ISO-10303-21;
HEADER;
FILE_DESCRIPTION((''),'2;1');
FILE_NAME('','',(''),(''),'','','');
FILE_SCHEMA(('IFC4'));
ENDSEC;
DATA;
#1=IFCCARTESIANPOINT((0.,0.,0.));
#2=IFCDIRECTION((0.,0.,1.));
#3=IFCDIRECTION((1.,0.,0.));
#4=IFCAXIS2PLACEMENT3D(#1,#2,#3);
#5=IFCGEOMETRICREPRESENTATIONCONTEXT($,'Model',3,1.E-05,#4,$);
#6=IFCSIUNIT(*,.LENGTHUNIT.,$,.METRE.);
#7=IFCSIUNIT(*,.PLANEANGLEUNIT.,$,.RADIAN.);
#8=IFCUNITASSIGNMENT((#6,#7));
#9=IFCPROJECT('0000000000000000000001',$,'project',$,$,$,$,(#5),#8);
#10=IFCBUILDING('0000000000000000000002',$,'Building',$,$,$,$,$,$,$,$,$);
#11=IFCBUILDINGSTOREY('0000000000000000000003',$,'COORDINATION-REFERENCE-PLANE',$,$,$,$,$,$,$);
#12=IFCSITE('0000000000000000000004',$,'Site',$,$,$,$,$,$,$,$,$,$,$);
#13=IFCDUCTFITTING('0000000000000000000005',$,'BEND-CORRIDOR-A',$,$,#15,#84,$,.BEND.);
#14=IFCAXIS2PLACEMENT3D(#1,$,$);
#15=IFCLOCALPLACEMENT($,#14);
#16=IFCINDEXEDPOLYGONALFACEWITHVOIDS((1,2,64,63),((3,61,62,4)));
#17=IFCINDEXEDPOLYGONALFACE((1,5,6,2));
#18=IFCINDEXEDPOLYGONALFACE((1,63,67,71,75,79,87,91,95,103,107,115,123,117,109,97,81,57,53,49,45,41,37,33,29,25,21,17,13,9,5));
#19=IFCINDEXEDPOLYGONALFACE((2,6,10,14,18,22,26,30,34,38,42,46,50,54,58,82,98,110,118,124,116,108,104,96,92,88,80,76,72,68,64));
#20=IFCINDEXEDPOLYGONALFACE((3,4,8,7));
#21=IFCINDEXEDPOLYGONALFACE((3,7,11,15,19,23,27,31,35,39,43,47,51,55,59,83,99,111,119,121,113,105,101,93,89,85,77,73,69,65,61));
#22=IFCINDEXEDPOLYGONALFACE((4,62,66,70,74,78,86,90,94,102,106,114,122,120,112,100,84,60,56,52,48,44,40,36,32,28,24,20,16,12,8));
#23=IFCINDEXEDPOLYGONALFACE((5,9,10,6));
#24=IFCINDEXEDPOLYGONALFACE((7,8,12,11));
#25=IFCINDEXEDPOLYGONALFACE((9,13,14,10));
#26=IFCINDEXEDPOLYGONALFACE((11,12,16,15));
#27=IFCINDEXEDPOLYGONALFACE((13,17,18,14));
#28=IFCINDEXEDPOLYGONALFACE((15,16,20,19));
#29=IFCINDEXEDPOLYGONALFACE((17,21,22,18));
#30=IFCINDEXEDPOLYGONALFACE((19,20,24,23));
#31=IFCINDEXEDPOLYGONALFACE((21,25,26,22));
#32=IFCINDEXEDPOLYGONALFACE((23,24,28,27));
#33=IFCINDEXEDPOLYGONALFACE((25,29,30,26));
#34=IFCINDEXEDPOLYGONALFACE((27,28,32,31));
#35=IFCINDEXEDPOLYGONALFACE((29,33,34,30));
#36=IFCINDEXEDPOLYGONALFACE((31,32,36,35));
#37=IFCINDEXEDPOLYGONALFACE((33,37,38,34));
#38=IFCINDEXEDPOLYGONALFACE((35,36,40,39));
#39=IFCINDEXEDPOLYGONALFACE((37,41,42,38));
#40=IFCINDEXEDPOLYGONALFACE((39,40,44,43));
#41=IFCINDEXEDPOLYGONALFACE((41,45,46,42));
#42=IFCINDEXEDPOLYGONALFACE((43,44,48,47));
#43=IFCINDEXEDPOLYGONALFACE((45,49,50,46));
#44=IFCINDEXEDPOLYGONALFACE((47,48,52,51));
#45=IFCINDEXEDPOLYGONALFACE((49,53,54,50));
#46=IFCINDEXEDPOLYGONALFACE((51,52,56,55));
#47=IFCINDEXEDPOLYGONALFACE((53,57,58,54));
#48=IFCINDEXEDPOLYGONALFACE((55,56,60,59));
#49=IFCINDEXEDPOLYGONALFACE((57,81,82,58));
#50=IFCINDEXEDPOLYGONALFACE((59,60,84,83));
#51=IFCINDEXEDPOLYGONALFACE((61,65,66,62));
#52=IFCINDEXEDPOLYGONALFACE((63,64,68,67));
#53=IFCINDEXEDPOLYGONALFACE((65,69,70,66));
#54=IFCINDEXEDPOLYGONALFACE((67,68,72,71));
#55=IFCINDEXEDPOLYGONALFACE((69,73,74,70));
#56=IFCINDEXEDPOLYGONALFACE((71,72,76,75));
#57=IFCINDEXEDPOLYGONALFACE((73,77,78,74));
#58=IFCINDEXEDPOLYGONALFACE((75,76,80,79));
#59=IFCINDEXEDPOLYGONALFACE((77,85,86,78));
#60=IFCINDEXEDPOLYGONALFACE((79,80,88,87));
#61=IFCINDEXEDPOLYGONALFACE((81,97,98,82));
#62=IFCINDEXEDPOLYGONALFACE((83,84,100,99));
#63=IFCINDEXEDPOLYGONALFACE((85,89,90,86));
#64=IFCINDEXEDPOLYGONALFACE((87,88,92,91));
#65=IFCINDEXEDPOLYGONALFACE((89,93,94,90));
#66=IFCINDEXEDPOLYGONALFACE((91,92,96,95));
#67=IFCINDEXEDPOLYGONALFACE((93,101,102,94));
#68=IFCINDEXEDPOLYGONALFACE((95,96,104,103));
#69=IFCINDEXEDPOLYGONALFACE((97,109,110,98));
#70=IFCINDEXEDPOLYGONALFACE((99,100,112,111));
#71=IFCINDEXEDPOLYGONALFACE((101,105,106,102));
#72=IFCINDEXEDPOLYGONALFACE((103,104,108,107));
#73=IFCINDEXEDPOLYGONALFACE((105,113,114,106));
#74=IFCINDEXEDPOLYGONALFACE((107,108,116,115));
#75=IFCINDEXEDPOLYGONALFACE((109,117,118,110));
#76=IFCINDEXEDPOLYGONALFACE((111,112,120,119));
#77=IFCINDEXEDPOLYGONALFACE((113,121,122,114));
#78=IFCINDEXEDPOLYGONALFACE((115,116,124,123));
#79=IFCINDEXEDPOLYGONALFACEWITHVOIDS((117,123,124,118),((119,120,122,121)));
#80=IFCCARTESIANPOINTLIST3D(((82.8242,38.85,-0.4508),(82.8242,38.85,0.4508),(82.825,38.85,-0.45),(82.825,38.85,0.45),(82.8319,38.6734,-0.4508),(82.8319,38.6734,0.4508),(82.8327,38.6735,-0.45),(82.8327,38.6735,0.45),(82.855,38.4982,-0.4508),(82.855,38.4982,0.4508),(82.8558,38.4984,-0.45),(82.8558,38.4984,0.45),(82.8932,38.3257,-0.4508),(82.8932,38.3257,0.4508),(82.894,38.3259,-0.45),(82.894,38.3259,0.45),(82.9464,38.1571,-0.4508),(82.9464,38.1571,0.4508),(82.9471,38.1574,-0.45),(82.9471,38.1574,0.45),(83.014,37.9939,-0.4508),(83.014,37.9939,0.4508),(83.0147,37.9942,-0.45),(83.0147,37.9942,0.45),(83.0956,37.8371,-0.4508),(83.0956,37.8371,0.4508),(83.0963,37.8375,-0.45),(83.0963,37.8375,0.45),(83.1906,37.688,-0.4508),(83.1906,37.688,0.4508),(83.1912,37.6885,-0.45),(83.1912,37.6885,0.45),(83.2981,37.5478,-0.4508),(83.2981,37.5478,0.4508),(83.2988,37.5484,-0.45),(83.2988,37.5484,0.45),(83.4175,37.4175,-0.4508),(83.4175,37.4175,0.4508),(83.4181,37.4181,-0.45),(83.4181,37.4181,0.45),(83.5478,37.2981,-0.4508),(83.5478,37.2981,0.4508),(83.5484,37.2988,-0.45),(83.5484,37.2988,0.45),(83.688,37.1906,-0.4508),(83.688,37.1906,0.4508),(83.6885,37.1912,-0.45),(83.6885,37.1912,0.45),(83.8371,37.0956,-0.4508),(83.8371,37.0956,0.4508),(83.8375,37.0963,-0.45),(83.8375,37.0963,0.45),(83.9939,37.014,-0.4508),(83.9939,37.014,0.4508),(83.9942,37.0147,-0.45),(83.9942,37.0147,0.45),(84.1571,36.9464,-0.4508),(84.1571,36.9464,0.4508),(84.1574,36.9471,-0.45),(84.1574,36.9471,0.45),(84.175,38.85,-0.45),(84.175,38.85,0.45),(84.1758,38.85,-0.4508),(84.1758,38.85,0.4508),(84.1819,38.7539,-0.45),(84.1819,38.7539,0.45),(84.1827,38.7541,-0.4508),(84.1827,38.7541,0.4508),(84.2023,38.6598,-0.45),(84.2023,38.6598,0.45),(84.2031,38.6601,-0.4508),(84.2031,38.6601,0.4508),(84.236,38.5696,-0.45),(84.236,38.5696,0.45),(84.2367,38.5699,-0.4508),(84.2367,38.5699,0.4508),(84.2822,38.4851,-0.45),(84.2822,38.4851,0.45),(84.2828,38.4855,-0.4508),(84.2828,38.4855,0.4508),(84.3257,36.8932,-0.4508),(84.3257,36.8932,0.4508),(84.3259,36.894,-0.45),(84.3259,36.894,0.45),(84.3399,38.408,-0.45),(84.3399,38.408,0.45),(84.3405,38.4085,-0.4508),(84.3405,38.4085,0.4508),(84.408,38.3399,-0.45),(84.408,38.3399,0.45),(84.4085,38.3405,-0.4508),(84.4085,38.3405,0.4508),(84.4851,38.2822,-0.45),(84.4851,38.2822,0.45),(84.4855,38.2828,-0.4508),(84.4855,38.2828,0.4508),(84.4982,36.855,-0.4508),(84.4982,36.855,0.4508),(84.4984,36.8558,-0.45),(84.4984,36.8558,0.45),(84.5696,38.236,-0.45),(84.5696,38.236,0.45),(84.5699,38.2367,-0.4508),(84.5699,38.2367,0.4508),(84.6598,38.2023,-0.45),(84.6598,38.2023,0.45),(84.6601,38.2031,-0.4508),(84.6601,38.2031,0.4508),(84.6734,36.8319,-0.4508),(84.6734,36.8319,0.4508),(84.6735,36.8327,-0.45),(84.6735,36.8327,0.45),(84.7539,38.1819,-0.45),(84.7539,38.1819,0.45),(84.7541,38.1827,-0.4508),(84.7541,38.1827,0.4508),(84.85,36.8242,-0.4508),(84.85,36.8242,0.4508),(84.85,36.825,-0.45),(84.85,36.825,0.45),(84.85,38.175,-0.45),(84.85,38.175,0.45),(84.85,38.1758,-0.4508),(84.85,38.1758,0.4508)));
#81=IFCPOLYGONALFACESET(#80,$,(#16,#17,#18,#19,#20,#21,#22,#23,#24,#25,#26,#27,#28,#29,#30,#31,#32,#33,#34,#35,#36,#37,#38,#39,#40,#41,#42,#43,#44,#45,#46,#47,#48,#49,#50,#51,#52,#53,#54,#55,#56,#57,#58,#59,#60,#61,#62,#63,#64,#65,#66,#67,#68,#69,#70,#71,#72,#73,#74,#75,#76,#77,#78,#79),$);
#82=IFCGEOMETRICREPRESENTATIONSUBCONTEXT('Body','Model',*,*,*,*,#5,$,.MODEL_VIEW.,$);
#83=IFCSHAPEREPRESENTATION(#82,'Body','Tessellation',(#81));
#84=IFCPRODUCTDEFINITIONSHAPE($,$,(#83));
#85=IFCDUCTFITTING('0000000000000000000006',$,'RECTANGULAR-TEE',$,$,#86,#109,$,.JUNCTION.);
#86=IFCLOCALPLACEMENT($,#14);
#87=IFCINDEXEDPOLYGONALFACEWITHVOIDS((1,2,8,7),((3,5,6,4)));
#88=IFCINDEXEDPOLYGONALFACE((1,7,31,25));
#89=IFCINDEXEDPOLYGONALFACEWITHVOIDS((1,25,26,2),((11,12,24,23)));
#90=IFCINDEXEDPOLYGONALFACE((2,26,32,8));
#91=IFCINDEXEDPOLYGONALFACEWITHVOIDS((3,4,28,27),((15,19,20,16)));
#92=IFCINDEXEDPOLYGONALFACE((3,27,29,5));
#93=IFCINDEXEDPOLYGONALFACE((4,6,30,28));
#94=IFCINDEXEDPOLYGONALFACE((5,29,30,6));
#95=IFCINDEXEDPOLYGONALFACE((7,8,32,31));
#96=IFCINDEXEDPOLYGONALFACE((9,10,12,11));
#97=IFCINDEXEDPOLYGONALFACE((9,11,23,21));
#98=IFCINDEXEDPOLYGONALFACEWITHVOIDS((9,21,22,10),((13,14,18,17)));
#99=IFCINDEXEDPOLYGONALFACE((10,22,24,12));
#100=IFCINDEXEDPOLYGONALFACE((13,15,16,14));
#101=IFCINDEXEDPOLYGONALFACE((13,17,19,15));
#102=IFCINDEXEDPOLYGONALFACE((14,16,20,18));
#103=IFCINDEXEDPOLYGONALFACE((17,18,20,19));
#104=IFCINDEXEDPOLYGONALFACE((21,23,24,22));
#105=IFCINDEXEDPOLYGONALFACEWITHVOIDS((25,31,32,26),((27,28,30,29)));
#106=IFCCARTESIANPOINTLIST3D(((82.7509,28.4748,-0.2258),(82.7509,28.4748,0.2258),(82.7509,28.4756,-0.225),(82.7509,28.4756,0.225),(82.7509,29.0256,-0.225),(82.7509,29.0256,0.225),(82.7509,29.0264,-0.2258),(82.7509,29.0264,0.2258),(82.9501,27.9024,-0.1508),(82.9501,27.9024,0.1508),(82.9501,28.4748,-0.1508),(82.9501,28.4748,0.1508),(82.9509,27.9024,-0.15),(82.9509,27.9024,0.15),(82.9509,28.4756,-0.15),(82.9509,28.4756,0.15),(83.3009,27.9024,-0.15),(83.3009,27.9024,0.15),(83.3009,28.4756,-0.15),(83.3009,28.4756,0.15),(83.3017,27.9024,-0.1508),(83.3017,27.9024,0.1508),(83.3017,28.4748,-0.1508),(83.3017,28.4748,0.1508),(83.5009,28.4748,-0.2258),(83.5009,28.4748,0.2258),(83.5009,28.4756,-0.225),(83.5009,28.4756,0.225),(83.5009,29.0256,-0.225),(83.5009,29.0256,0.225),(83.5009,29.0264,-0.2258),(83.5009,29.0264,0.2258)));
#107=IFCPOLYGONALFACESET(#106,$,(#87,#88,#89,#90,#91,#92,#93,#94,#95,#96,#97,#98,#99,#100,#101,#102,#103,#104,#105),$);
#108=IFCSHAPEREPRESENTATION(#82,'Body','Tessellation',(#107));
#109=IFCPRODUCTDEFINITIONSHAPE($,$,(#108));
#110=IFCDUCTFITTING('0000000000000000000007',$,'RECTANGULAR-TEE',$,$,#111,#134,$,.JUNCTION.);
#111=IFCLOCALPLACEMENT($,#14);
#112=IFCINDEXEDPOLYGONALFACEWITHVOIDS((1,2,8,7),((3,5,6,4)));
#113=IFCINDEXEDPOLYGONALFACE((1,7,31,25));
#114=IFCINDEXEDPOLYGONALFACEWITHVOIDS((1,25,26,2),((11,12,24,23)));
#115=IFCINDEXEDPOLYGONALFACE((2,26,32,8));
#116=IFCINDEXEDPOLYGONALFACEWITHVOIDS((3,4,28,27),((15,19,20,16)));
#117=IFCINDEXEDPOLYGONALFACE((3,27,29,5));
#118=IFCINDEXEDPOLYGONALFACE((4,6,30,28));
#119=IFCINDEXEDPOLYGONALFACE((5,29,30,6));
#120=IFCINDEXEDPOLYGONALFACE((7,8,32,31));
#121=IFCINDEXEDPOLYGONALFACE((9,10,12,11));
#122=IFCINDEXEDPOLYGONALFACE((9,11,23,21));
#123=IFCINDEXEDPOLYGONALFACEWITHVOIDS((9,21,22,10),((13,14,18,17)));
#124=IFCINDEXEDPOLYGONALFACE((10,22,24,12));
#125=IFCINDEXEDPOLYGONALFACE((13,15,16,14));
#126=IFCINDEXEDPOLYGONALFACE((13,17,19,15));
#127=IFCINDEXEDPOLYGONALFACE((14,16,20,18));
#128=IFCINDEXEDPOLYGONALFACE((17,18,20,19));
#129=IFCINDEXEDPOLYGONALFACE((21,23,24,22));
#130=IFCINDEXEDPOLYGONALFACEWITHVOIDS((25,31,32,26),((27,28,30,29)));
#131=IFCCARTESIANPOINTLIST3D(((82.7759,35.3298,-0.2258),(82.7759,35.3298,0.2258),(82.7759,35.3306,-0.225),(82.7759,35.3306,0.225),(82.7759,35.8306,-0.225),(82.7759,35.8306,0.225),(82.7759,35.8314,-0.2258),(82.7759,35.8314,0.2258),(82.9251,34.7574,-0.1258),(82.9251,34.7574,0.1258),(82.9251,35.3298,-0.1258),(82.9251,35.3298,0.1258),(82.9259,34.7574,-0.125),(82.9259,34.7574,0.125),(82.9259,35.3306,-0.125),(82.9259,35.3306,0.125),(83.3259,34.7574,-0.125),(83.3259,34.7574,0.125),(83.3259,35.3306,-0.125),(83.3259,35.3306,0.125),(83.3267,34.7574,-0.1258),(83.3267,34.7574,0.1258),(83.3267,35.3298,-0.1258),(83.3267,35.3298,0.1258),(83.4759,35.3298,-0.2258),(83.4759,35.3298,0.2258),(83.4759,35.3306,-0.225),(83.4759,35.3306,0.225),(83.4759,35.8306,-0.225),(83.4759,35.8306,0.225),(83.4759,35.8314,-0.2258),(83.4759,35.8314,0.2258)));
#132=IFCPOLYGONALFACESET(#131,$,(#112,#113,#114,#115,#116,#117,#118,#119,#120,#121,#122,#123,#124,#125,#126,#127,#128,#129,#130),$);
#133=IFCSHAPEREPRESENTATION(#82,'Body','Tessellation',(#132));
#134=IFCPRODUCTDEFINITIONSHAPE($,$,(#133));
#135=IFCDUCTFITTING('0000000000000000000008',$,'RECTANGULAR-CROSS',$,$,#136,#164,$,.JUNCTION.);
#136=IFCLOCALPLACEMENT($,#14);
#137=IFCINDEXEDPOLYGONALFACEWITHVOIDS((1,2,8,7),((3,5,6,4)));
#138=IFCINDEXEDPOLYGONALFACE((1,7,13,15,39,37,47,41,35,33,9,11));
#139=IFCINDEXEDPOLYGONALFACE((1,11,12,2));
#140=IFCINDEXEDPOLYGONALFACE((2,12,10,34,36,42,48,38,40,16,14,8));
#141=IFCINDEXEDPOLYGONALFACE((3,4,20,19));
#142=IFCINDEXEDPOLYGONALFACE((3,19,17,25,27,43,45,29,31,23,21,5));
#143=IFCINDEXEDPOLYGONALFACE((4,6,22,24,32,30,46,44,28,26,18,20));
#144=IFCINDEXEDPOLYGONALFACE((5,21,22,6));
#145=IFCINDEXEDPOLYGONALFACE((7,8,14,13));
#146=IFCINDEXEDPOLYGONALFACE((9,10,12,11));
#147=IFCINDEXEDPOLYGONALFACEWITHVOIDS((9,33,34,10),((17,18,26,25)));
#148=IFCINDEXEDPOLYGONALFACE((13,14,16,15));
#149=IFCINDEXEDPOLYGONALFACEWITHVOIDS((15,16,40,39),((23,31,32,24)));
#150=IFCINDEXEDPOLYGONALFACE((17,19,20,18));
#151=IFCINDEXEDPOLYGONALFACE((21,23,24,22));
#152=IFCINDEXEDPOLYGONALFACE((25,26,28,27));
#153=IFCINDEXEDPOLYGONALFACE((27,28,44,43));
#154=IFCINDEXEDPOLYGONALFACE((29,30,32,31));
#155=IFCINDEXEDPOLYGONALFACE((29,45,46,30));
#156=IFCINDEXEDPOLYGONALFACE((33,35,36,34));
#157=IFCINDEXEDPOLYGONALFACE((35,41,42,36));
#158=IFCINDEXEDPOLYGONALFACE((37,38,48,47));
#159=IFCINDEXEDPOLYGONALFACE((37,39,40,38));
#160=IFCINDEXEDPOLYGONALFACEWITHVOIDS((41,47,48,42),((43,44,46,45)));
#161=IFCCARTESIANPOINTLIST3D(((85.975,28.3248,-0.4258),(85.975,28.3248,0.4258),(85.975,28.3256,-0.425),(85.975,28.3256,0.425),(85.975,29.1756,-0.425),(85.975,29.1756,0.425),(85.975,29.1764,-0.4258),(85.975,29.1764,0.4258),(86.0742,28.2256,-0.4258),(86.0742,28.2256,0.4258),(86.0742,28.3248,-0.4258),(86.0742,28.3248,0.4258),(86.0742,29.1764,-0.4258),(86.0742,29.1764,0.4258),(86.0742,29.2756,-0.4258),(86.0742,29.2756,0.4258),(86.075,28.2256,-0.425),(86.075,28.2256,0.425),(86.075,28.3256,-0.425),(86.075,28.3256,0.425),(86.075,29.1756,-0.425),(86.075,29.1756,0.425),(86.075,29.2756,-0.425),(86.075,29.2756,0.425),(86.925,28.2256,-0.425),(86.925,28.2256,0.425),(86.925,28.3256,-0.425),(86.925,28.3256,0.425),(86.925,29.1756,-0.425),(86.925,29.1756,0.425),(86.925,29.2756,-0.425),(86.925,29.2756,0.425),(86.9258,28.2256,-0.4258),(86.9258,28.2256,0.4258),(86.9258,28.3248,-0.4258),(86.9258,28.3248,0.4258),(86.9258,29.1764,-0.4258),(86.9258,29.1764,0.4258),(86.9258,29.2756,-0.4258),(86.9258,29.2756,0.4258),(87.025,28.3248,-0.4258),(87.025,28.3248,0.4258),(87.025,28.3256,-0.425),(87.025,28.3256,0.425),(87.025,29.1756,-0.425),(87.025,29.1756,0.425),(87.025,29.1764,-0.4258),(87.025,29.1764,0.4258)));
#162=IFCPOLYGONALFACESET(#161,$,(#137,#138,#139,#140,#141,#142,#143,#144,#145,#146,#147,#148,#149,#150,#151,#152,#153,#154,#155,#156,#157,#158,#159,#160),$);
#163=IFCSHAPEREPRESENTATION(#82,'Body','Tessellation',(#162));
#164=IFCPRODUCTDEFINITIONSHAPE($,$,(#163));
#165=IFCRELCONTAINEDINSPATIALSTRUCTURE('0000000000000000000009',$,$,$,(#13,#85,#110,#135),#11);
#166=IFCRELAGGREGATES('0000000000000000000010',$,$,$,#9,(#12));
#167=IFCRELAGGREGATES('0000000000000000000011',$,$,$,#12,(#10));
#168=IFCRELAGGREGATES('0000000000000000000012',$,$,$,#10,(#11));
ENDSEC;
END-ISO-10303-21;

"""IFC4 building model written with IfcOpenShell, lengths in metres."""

from ifc_helpers import new_model, entity, si_unit, frame, origin_with_axes, place, context, subcontext, project, spatial, rectangle, extrude, boolean, element, save


model = new_model("IFC4")

# Units and contexts
model_context = context("Model", 3, precision=1e-05, world=origin_with_axes())
body_context_1 = subcontext(model_context, "Body", "Model", "MODEL_VIEW")
ifc_project = project(units=[si_unit("LENGTHUNIT", "METRE"), si_unit("PLANEANGLEUNIT", "RADIAN")], contexts=[model_context])

# Site, building, storey
site = spatial("IfcSite", under=ifc_project, Name="Site")
building = spatial("IfcBuilding", under=site, Name="Building")
storey = spatial("IfcBuildingStorey", under=building, Name="COORDINATION-REFERENCE-PLANE")

# Duct fittings
duct_fitting_1_placement = place(None, frame((84.85, 38.85, 0.0), z_axis=(0.0, 0.0, 1.0), x_axis=(-1.0, 0.0, 0.0)))
cartesian_point_1 = entity("IfcCartesianPoint", [0.0, 0.0, 0.0])
element("IfcDuctFitting", 1, at=duct_fitting_1_placement, inside=storey, Name="BEND-CORRIDOR-A", PredefinedType="BEND", context=body_context_1, shape_type="SweptSolid", body=[
    entity("IfcRevolvedAreaSolid", entity("IfcRectangleHollowProfileDef", "AREA", None, entity("IfcAxis2Placement2D", entity("IfcCartesianPoint", [1.35, 0.0])), 1.3516, 0.9016, 0.0008), entity("IfcAxis2Placement3D", cartesian_point_1, entity("IfcDirection", [0.0, -1.0, 0.0]), entity("IfcDirection", [1.0, 0.0, 0.0])), entity("IfcAxis1Placement", cartesian_point_1, entity("IfcDirection", [0.0, 1.0, 0.0])), 1.570796),
])
duct_fitting_2_placement = place(None, frame((83.1259, 28.7506, 0.0), z_axis=(-1.0, 0.0, 0.0), x_axis=(0.0, -1.0, 0.0)))
solid_1 = boolean("UNION", extrude(rectangle(XDim=0.55, YDim=0.45), frame((0.0, 0.0, -0.375), z_axis=(0.0, 0.0, 1.0), x_axis=(1.0, 0.0, 0.0)), (0.0, 0.0, 1.0), 0.75), extrude(rectangle(XDim=0.35, YDim=0.3), frame((0.0, 0.0, 0.0), z_axis=(1.0, 0.0, 0.0), x_axis=(0.0, 0.0, -1.0)), (0.0, 0.0, 1.0), 0.8482))
element("IfcDuctFitting", 2, at=duct_fitting_2_placement, inside=storey, Name="RECTANGULAR-TEE", PredefinedType="JUNCTION", context=body_context_1, shape_type="CSG", body=[
    boolean("DIFFERENCE", boolean("UNION", extrude(rectangle(XDim=0.5516, YDim=0.4516), frame((0.0, 0.0, -0.375), z_axis=(0.0, 0.0, 1.0), x_axis=(1.0, 0.0, 0.0)), (0.0, 0.0, 1.0), 0.75), extrude(rectangle(XDim=0.3516, YDim=0.3016), frame((0.0, 0.0, 0.0), z_axis=(1.0, 0.0, 0.0), x_axis=(0.0, 0.0, -1.0)), (0.0, 0.0, 1.0), 0.8482)), solid_1),
])
duct_fitting_3_placement = place(None, frame((83.1259, 35.5806, 0.0), z_axis=(-1.0, 0.0, 0.0), x_axis=(0.0, -1.0, 0.0)))
solid_2 = boolean("UNION", extrude(rectangle(XDim=0.5, YDim=0.45), frame((0.0, 0.0, -0.35), z_axis=(0.0, 0.0, 1.0), x_axis=(1.0, 0.0, 0.0)), (0.0, 0.0, 1.0), 0.7), extrude(rectangle(XDim=0.4, YDim=0.25), frame((0.0, 0.0, 0.0), z_axis=(1.0, 0.0, 0.0), x_axis=(0.0, 0.0, -1.0)), (0.0, 0.0, 1.0), 0.8232))
element("IfcDuctFitting", 3, at=duct_fitting_3_placement, inside=storey, Name="RECTANGULAR-TEE", PredefinedType="JUNCTION", context=body_context_1, shape_type="CSG", body=[
    boolean("DIFFERENCE", boolean("UNION", extrude(rectangle(XDim=0.5016, YDim=0.4516), frame((0.0, 0.0, -0.35), z_axis=(0.0, 0.0, 1.0), x_axis=(1.0, 0.0, 0.0)), (0.0, 0.0, 1.0), 0.7), extrude(rectangle(XDim=0.4016, YDim=0.2516), frame((0.0, 0.0, 0.0), z_axis=(1.0, 0.0, 0.0), x_axis=(0.0, 0.0, -1.0)), (0.0, 0.0, 1.0), 0.8232)), solid_2),
])
duct_fitting_4_placement = place(None, frame((86.5, 28.7506, 0.0), z_axis=(0.0, -1.0, 0.0), x_axis=(1.0, 0.0, 0.0)))
solid_3 = boolean("UNION", extrude(rectangle(XDim=0.85, YDim=0.85), frame((0.0, 0.0, -0.525), z_axis=(0.0, 0.0, 1.0), x_axis=(1.0, 0.0, 0.0)), (0.0, 0.0, 1.0), 1.05), extrude(rectangle(XDim=0.85, YDim=0.85), frame((-0.525, 0.0, 0.0), z_axis=(1.0, 0.0, 0.0), x_axis=(0.0, 0.0, -1.0)), (0.0, 0.0, 1.0), 1.05))
element("IfcDuctFitting", 4, at=duct_fitting_4_placement, inside=storey, Name="RECTANGULAR-CROSS", PredefinedType="JUNCTION", context=body_context_1, shape_type="CSG", body=[
    boolean("DIFFERENCE", boolean("UNION", extrude(rectangle(XDim=0.8516, YDim=0.8516), frame((0.0, 0.0, -0.525), z_axis=(0.0, 0.0, 1.0), x_axis=(1.0, 0.0, 0.0)), (0.0, 0.0, 1.0), 1.05), extrude(rectangle(XDim=0.8516, YDim=0.8516), frame((-0.525, 0.0, 0.0), z_axis=(1.0, 0.0, 0.0), x_axis=(0.0, 0.0, -1.0)), (0.0, 0.0, 1.0), 1.05)), solid_3),
])

save(model, "model.ifc")
